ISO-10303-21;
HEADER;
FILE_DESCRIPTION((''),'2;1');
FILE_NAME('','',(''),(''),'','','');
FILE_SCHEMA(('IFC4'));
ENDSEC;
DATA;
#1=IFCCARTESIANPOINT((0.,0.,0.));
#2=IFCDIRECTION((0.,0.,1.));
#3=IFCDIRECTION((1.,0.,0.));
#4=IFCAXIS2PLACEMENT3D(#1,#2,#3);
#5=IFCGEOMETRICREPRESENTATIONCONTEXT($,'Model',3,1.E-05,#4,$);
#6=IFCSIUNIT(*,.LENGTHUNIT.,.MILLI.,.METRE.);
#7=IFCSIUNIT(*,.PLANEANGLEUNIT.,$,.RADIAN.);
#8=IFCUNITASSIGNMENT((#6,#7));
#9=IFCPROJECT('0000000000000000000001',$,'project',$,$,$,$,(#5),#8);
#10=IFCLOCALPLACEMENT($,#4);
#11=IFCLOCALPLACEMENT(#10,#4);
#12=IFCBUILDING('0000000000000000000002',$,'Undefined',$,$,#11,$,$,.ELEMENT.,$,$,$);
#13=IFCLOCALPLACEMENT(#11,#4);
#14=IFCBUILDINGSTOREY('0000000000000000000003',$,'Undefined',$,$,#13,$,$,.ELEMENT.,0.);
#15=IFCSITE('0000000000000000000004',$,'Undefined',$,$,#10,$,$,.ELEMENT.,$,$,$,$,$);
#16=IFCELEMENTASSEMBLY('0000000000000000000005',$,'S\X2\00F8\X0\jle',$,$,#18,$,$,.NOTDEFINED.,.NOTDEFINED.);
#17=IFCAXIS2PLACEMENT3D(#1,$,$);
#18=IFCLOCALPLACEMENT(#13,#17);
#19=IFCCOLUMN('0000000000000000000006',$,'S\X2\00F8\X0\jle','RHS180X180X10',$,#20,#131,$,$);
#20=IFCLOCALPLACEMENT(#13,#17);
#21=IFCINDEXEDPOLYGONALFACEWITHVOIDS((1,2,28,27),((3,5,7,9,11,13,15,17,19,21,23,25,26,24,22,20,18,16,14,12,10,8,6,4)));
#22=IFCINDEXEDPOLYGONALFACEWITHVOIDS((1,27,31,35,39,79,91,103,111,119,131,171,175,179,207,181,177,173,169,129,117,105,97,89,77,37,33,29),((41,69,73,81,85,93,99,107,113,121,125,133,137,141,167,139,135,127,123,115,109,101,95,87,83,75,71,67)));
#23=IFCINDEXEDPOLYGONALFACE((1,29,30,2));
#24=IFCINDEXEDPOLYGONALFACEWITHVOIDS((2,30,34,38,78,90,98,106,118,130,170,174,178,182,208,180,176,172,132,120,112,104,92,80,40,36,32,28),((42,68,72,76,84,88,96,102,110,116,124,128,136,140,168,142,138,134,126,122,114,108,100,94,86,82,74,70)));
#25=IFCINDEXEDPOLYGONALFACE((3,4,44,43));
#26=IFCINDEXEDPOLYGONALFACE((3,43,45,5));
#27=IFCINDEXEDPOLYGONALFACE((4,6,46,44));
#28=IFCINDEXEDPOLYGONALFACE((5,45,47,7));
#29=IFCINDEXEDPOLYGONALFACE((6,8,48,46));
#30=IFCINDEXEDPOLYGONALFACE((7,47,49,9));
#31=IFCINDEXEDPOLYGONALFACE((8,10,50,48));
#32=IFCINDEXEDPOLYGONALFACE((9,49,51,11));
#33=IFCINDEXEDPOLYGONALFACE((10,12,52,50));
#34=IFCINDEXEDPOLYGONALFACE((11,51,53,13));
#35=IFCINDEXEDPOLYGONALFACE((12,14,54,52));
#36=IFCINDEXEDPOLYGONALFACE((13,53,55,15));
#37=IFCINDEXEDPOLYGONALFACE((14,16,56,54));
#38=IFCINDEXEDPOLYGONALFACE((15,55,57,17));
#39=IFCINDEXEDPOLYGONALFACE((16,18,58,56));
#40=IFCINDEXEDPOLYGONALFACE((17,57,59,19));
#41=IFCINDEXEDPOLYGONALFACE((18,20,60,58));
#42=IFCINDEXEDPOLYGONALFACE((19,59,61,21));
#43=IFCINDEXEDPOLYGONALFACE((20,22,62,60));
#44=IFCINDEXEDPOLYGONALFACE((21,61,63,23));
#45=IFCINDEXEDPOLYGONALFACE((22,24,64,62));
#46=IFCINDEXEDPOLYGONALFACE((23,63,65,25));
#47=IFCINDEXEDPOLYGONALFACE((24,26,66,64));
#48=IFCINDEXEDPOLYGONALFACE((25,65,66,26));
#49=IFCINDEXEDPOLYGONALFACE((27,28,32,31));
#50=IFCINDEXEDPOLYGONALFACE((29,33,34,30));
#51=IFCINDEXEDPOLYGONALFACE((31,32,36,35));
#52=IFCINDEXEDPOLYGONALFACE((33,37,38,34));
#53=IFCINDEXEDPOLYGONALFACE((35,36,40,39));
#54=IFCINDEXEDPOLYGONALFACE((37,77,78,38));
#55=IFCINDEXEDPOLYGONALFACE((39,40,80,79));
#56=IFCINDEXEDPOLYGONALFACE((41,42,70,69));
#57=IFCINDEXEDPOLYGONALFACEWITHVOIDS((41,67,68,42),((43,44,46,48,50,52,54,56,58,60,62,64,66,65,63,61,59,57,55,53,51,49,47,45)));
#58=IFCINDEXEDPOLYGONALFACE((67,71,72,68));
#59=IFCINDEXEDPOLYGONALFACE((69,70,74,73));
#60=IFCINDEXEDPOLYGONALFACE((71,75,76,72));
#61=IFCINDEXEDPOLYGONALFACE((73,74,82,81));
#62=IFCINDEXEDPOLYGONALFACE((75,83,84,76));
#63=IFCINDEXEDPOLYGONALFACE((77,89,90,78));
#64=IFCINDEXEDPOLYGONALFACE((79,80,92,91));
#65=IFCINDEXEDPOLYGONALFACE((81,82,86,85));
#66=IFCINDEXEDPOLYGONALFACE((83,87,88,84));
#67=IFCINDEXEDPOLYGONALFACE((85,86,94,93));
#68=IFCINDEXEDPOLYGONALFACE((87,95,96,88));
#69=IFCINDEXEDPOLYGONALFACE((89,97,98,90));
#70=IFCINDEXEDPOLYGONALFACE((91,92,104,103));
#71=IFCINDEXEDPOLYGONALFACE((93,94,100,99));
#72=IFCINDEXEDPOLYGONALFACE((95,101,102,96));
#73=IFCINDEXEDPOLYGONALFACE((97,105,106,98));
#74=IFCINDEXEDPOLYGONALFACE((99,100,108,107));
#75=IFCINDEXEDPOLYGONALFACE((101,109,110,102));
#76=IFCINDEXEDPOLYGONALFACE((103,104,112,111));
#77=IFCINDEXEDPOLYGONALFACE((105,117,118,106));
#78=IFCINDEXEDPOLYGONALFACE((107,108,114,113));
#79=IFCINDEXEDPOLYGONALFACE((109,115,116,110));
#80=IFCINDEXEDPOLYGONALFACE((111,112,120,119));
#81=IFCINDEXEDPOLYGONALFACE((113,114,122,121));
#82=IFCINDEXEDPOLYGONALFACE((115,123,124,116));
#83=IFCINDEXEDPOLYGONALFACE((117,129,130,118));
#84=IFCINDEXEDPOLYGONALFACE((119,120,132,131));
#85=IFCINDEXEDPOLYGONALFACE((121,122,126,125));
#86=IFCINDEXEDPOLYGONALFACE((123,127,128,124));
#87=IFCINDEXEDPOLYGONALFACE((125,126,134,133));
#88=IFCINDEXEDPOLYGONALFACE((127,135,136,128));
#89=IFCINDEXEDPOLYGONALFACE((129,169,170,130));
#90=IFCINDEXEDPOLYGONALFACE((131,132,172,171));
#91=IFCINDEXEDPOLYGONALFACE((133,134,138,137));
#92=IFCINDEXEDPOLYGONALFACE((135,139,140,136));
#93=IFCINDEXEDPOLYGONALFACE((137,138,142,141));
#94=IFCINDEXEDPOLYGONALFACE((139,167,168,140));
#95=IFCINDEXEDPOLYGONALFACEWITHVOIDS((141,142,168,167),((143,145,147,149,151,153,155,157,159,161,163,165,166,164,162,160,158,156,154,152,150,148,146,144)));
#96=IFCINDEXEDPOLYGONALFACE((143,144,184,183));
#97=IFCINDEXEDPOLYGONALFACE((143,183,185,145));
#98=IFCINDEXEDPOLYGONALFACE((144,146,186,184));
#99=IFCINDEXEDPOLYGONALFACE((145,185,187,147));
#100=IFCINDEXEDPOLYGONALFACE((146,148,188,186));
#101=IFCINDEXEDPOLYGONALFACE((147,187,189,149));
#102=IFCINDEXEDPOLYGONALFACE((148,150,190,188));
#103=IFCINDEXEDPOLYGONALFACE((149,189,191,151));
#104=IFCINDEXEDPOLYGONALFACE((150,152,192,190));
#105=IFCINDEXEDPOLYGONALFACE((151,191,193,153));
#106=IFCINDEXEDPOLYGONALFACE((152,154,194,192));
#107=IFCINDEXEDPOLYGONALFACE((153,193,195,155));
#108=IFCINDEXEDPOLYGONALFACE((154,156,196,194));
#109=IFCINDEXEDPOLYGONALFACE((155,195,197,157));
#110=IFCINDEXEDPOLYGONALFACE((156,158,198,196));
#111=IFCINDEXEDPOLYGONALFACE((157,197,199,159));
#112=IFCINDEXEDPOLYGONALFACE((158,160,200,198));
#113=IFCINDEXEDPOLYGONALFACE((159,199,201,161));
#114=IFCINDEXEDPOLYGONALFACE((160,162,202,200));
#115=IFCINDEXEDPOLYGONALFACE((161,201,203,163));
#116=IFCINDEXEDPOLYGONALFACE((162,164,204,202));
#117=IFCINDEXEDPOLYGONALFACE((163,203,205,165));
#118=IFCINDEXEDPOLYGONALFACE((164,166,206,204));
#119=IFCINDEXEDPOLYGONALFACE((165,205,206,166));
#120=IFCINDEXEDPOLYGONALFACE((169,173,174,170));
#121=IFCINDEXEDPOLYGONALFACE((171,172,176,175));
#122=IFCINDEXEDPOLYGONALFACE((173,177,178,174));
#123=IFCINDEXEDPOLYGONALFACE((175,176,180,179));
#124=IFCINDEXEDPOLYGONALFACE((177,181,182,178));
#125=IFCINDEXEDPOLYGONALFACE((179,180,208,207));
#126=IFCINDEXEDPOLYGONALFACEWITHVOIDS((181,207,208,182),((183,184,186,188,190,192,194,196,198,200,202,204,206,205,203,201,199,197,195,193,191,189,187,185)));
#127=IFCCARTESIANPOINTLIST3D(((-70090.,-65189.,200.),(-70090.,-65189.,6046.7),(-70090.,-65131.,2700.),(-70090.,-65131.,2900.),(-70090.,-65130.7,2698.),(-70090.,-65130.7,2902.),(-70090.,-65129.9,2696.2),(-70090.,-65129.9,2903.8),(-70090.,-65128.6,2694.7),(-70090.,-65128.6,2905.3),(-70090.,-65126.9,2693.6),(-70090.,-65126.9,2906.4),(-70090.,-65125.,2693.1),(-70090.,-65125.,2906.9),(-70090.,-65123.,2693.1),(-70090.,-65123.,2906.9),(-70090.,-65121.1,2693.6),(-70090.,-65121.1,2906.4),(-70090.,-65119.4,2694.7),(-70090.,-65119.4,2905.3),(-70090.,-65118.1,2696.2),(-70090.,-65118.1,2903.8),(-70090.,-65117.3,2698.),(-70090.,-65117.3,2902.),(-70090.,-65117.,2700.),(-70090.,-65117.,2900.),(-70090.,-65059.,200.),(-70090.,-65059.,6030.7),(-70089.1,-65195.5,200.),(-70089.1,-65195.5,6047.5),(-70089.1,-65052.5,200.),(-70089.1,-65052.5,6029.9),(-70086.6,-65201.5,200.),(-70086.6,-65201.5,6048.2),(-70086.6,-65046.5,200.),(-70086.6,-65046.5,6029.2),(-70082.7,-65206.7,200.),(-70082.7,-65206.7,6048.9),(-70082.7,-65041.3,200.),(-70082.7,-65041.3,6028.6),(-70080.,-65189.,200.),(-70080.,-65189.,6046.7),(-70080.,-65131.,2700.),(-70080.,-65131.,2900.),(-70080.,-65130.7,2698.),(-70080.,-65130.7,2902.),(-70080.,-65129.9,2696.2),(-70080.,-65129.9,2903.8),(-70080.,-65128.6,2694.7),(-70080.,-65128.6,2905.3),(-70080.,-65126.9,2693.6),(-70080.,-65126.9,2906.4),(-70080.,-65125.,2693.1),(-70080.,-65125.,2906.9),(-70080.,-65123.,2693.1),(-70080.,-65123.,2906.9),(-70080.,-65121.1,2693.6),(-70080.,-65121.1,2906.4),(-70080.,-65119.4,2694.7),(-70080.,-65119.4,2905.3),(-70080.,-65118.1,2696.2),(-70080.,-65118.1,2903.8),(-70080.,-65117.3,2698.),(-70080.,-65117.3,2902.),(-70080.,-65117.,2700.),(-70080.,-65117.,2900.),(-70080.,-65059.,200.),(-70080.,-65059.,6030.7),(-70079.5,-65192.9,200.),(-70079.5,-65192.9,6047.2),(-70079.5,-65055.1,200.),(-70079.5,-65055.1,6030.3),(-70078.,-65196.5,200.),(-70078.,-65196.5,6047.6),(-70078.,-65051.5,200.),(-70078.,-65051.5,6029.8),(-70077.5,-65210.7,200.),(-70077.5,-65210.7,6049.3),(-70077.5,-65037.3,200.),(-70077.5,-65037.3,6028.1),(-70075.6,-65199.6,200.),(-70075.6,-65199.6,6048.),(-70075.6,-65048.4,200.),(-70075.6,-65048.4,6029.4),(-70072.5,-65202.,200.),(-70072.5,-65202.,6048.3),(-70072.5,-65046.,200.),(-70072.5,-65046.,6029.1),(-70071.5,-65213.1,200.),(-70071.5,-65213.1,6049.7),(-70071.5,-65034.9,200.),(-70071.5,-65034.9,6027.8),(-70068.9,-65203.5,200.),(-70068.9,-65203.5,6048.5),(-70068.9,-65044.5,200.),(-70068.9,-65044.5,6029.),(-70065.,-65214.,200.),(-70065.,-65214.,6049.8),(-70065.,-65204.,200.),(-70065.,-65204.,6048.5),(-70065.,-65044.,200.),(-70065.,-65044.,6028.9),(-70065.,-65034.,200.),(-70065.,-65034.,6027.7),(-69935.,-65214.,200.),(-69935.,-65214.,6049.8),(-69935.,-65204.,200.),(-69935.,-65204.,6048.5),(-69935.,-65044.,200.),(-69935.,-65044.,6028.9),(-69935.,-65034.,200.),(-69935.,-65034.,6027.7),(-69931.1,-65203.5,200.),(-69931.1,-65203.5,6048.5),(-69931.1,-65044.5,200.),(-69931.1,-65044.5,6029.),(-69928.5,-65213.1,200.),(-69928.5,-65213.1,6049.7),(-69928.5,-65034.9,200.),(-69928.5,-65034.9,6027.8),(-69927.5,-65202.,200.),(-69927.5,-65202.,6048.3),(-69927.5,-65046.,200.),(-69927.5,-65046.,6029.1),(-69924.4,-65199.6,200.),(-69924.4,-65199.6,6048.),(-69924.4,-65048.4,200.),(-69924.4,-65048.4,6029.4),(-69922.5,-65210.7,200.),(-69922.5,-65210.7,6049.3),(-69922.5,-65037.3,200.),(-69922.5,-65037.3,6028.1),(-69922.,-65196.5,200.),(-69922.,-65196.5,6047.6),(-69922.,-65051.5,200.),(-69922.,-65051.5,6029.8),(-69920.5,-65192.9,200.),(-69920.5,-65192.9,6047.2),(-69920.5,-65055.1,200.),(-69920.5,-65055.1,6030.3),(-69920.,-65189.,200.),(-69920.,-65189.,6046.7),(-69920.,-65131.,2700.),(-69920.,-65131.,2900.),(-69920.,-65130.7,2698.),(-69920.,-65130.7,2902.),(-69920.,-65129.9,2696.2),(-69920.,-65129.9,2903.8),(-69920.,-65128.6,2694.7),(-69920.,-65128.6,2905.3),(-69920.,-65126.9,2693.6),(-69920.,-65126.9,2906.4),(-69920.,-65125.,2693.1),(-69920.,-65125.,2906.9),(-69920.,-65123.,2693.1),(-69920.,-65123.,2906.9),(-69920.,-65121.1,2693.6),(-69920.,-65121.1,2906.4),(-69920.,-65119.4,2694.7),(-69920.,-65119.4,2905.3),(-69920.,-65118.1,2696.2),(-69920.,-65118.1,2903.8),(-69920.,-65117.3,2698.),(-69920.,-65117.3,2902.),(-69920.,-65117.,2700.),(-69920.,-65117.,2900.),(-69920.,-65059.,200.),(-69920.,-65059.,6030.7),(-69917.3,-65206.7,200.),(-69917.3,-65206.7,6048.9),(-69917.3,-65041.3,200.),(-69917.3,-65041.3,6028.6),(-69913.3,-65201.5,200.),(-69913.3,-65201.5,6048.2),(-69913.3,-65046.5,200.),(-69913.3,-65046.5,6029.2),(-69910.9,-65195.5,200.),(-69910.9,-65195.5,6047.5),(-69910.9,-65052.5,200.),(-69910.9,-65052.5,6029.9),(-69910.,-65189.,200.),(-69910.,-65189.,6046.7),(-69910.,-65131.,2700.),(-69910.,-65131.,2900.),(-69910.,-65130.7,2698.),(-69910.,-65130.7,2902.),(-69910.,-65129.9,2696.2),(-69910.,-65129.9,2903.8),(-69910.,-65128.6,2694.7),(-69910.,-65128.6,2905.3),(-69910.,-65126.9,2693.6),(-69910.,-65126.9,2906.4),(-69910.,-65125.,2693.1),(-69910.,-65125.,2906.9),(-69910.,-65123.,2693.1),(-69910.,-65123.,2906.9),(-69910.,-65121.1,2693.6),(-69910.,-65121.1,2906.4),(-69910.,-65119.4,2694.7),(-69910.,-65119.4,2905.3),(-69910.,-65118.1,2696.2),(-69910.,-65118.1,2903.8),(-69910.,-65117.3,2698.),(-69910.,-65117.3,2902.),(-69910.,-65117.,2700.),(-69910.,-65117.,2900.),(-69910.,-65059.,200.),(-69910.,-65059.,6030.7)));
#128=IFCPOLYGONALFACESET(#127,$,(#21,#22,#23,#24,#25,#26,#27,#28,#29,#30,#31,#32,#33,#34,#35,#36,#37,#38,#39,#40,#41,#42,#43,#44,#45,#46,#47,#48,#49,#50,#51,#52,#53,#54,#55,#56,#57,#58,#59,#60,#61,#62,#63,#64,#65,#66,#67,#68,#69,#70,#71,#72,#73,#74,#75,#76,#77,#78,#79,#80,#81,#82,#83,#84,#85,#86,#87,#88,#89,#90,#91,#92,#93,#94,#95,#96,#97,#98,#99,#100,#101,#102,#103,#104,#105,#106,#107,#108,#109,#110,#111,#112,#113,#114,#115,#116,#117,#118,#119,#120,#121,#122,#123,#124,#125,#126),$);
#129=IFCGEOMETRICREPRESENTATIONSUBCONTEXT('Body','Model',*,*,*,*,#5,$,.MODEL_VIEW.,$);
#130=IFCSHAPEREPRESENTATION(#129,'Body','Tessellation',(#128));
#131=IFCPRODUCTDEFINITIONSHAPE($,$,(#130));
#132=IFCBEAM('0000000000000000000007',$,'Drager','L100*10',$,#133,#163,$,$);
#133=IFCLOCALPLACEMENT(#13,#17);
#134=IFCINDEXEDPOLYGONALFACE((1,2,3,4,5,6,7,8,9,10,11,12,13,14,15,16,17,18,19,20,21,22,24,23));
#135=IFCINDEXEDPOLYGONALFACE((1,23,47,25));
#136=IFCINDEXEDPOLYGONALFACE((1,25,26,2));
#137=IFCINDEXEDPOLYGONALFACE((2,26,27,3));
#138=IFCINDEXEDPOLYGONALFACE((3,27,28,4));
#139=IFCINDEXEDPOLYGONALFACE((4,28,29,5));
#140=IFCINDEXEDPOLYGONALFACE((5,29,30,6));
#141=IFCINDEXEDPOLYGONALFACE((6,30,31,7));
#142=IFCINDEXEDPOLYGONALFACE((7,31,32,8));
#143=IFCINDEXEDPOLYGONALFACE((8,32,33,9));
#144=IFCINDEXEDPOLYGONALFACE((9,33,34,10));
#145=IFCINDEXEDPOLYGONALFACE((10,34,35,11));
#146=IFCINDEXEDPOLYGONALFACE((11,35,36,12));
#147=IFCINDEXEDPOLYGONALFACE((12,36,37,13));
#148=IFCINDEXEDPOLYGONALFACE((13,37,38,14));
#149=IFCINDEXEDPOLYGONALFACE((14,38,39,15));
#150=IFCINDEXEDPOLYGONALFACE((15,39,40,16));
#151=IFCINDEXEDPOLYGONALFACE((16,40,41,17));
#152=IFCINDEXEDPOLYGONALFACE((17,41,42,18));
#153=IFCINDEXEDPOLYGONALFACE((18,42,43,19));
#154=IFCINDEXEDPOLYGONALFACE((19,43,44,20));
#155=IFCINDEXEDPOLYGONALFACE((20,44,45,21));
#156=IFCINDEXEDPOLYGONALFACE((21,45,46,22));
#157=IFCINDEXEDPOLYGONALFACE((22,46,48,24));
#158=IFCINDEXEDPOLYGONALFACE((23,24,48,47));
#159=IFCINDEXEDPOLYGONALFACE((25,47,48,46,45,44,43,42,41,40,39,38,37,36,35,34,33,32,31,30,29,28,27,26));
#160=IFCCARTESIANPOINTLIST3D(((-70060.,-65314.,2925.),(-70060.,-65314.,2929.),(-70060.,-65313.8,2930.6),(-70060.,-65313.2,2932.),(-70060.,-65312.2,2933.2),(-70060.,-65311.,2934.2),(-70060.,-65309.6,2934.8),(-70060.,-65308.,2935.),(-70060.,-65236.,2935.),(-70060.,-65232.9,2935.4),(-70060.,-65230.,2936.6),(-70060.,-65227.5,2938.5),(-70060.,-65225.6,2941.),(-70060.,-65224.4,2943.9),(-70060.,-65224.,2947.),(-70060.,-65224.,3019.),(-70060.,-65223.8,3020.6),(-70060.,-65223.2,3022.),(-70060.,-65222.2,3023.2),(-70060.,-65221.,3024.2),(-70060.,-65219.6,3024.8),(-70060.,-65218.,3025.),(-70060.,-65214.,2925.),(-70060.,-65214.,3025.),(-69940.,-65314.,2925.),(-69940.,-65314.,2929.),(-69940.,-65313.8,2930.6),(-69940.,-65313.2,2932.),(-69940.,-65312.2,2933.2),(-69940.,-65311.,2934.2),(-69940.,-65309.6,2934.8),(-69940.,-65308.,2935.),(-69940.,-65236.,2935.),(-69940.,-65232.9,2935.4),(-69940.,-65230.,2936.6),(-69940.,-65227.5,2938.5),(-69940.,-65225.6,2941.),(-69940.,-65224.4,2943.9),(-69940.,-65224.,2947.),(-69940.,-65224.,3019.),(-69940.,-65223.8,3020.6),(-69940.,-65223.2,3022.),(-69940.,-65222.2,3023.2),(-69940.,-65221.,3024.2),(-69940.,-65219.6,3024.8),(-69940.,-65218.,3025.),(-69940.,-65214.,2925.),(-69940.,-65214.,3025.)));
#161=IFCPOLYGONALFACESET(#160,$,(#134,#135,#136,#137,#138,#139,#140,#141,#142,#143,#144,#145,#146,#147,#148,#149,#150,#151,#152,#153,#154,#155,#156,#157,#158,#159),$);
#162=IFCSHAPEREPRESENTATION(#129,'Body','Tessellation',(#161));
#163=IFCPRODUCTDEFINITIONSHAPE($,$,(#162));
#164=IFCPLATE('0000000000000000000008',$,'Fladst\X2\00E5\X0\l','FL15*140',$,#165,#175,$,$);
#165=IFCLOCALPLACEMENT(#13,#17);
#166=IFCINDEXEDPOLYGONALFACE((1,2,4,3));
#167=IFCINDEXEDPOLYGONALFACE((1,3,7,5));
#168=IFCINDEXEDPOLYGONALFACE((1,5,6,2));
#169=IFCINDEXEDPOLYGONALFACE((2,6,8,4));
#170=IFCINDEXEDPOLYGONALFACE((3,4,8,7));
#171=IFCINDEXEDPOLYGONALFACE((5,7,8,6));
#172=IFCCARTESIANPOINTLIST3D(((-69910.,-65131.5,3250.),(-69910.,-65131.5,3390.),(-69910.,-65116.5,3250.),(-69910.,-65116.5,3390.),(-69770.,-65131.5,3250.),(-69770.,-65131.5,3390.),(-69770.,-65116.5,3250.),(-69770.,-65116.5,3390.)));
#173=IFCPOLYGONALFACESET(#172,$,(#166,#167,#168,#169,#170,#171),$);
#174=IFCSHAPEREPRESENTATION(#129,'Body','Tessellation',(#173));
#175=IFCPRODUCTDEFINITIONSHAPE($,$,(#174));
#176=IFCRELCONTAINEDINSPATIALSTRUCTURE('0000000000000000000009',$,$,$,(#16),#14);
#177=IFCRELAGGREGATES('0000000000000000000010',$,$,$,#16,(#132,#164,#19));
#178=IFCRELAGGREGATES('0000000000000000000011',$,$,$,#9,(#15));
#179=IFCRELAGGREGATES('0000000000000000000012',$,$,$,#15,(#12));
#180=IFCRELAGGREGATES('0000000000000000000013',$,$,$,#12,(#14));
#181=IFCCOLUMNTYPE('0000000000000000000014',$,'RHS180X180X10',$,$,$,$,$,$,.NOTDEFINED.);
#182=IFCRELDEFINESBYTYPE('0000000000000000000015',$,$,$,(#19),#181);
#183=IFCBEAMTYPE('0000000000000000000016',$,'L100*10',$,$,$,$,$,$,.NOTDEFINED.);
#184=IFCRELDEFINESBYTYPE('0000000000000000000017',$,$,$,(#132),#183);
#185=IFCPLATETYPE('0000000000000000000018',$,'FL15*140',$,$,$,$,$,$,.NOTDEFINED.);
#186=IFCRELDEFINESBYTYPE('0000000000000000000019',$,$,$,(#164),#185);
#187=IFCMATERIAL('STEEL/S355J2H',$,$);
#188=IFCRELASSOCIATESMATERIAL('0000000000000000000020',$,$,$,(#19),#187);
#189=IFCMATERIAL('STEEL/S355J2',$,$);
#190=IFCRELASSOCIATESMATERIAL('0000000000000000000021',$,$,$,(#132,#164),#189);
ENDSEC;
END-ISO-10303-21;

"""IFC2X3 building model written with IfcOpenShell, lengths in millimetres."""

from ifc_helpers import new_model, si_unit, frame, frame_2d, origin_with_axes, origin_2d_with_axis, place, context, subcontext, project, spatial, polyline, circle_curve, parameter, trimmed, segment, composite_curve, hollow_rectangle, l_section, outline, extrude, boolean, halfspace, material, type_object, element, aggregate, save


model = new_model("IFC2X3")

# Units and contexts
model_context = context("Model", 3, precision=1e-05, world=origin_with_axes())
body_context = subcontext(model_context, "Body", "Model", "MODEL_VIEW")
ifc_project = project(units=[si_unit("LENGTHUNIT", "METRE", prefix="MILLI"), si_unit("PLANEANGLEUNIT", "RADIAN")], contexts=[model_context])

# Site, building, storey
site_placement = place(None, origin_with_axes())
site = spatial("IfcSite", under=ifc_project, at=site_placement, Name="Undefined", CompositionType="ELEMENT")
building_placement = place(site_placement, origin_with_axes())
building = spatial("IfcBuilding", under=site, at=building_placement, Name="Undefined", CompositionType="ELEMENT")
storey_placement = place(building_placement, origin_with_axes())
storey = spatial("IfcBuildingStorey", under=building, at=storey_placement, Name="Undefined", CompositionType="ELEMENT", Elevation=0.0)

# Element assembly, column
assembly_1_placement = place(storey_placement, origin_with_axes())
assembly_1 = element("IfcElementAssembly", 1, at=assembly_1_placement, inside=storey, Name="Søjle", AssemblyPlace="NOTDEFINED", PredefinedType="NOTDEFINED")
ifc_material_1 = material(Name="STEEL/S355J2H")
column_type = type_object("IfcColumnType", Name="RHS180X180X10", PredefinedType="NOTDEFINED")
column_placement = place(assembly_1_placement, frame((-70000.0, -65124.0, 200.0), z_axis=(0.0, 0.0, 1.0), x_axis=(0.0, 1.0, 0.0)))
column = element("IfcColumn", 2, at=column_placement, type_object=column_type, material=ifc_material_1, Name="Søjle", Description="RHS180X180X10", context=body_context, shape_type="CSG", body=[
    boolean("DIFFERENCE", boolean("DIFFERENCE", boolean("DIFFERENCE", extrude(hollow_rectangle(XDim=180.0, YDim=180.0, WallThickness=10.0, InnerFilletRadius=15.0, OuterFilletRadius=25.0, at=origin_2d_with_axis()), frame((0.0, 0.0, 5849.9), z_axis=(0.0, 0.0, -1.0), x_axis=(0.0, 1.0, 0.0)), (0.0, 0.0, 1.0), 5849.9), extrude(outline(composite_curve([segment(trimmed(circle_curve(frame_2d((7.0, 7.0), x_axis=(-1.0, 0.0)), 7.0), [parameter(0.0)], [parameter(1.570796)], True, "PARAMETER"), True, "CONTINUOUS"), segment(polyline([(7.0, 0.0), (207.0, 0.0)]), True, "CONTINUOUS"), segment(trimmed(circle_curve(frame_2d((207.0, 7.0), x_axis=(0.0, -1.0)), 7.0), [parameter(0.0)], [parameter(1.570796)], True, "PARAMETER"), True, "CONTINUOUS"), segment(polyline([(214.0, 7.0), (214.0, 7.0)]), True, "CONTINUOUS"), segment(trimmed(circle_curve(frame_2d((207.0, 7.0), x_axis=(1.0, 0.0)), 7.0), [parameter(0.0)], [parameter(1.570796)], True, "PARAMETER"), True, "CONTINUOUS"), segment(polyline([(207.0, 14.0), (7.0, 14.0)]), True, "CONTINUOUS"), segment(trimmed(circle_curve(frame_2d((7.0, 7.0), x_axis=(0.0, 1.0)), 7.0), [parameter(0.0)], [parameter(1.570796)], True, "PARAMETER"), True, "CONTINUOUS"), segment(polyline([(0.0, 7.0), (0.0, 7.0)]), True, "CONTINUOUS")], self_intersect=True)), frame((-7.0, 90.0, 2707.0), z_axis=(0.0, -1.0, 0.0), x_axis=(0.0, 0.0, -1.0)), (0.0, 0.0, 1.0), 20.0)), extrude(outline(composite_curve([segment(trimmed(circle_curve(frame_2d((7.0, 7.0), x_axis=(-1.0, 0.0)), 7.0), [parameter(0.0)], [parameter(1.570796)], True, "PARAMETER"), True, "CONTINUOUS"), segment(polyline([(7.0, 0.0), (207.0, 0.0)]), True, "CONTINUOUS"), segment(trimmed(circle_curve(frame_2d((207.0, 7.0), x_axis=(0.0, -1.0)), 7.0), [parameter(0.0)], [parameter(1.570796)], True, "PARAMETER"), True, "CONTINUOUS"), segment(polyline([(214.0, 7.0), (214.0, 7.0)]), True, "CONTINUOUS"), segment(trimmed(circle_curve(frame_2d((207.0, 7.0), x_axis=(1.0, 0.0)), 7.0), [parameter(0.0)], [parameter(1.570796)], True, "PARAMETER"), True, "CONTINUOUS"), segment(polyline([(207.0, 14.0), (7.0, 14.0)]), True, "CONTINUOUS"), segment(trimmed(circle_curve(frame_2d((7.0, 7.0), x_axis=(0.0, 1.0)), 7.0), [parameter(0.0)], [parameter(1.570796)], True, "PARAMETER"), True, "CONTINUOUS"), segment(polyline([(0.0, 7.0), (0.0, 7.0)]), True, "CONTINUOUS")], self_intersect=True)), frame((7.0, -90.0, 2707.0), z_axis=(0.0, 1.0, 0.0), x_axis=(0.0, 0.0, -1.0)), (0.0, 0.0, 1.0), 20.0)), halfspace(frame((-90.0, 0.0, 5849.8), z_axis=(-0.121869, 0.0, -0.992546), x_axis=(0.0, -1.0, 0.0)), True)),
])

# Beam
ifc_material_2 = material(Name="STEEL/S355J2")
beam_type_1 = type_object("IfcBeamType", Name="L100*10", PredefinedType="NOTDEFINED")
beam_1_placement = place(assembly_1_placement, frame((-70060.0, -65264.0, 2975.0), z_axis=(0.0, 0.0, 1.0), x_axis=(1.0, 0.0, 0.0)))
beam_1 = element("IfcBeam", 3, at=beam_1_placement, type_object=beam_type_1, material=ifc_material_2, Name="Drager", Description="L100*10", context=body_context, shape_type="SweptSolid", body=[
    extrude(l_section(Depth=100.0, Width=100.0, Thickness=10.0, FilletRadius=12.0, EdgeRadius=6.0, at=origin_2d_with_axis()), frame((120.0, 0.0, 0.0), z_axis=(-1.0, 0.0, 0.0), x_axis=(0.0, -1.0, 0.0)), (0.0, 0.0, 1.0), 120.0),
])

# Plate
plate_type_1 = type_object("IfcPlateType", Name="FL15*140", PredefinedType="NOTDEFINED")
plate_1_placement = place(assembly_1_placement, frame((-69910.0, -65124.0, 3250.0), z_axis=(0.0, -1.0, 0.0), x_axis=(1.0, 0.0, 0.0)))
plate_1 = element("IfcPlate", 4, at=plate_1_placement, type_object=plate_type_1, material=ifc_material_2, Name="Fladstål", Description="FL15*140", context=body_context, shape_type="SweptSolid", body=[
    extrude(outline(polyline([(0.0, 0.0), (140.0, 0.0), (140.0, 140.0), (0.0, 140.0), (0.0, 0.0)])), frame((0.0, 0.0, -7.5), z_axis=(0.0, 0.0, 1.0), x_axis=(1.0, 0.0, 0.0)), (0.0, 0.0, 1.0), 15.0),
])

aggregate(assembly_1, [beam_1, plate_1, column])

save(model, "model.ifc")
